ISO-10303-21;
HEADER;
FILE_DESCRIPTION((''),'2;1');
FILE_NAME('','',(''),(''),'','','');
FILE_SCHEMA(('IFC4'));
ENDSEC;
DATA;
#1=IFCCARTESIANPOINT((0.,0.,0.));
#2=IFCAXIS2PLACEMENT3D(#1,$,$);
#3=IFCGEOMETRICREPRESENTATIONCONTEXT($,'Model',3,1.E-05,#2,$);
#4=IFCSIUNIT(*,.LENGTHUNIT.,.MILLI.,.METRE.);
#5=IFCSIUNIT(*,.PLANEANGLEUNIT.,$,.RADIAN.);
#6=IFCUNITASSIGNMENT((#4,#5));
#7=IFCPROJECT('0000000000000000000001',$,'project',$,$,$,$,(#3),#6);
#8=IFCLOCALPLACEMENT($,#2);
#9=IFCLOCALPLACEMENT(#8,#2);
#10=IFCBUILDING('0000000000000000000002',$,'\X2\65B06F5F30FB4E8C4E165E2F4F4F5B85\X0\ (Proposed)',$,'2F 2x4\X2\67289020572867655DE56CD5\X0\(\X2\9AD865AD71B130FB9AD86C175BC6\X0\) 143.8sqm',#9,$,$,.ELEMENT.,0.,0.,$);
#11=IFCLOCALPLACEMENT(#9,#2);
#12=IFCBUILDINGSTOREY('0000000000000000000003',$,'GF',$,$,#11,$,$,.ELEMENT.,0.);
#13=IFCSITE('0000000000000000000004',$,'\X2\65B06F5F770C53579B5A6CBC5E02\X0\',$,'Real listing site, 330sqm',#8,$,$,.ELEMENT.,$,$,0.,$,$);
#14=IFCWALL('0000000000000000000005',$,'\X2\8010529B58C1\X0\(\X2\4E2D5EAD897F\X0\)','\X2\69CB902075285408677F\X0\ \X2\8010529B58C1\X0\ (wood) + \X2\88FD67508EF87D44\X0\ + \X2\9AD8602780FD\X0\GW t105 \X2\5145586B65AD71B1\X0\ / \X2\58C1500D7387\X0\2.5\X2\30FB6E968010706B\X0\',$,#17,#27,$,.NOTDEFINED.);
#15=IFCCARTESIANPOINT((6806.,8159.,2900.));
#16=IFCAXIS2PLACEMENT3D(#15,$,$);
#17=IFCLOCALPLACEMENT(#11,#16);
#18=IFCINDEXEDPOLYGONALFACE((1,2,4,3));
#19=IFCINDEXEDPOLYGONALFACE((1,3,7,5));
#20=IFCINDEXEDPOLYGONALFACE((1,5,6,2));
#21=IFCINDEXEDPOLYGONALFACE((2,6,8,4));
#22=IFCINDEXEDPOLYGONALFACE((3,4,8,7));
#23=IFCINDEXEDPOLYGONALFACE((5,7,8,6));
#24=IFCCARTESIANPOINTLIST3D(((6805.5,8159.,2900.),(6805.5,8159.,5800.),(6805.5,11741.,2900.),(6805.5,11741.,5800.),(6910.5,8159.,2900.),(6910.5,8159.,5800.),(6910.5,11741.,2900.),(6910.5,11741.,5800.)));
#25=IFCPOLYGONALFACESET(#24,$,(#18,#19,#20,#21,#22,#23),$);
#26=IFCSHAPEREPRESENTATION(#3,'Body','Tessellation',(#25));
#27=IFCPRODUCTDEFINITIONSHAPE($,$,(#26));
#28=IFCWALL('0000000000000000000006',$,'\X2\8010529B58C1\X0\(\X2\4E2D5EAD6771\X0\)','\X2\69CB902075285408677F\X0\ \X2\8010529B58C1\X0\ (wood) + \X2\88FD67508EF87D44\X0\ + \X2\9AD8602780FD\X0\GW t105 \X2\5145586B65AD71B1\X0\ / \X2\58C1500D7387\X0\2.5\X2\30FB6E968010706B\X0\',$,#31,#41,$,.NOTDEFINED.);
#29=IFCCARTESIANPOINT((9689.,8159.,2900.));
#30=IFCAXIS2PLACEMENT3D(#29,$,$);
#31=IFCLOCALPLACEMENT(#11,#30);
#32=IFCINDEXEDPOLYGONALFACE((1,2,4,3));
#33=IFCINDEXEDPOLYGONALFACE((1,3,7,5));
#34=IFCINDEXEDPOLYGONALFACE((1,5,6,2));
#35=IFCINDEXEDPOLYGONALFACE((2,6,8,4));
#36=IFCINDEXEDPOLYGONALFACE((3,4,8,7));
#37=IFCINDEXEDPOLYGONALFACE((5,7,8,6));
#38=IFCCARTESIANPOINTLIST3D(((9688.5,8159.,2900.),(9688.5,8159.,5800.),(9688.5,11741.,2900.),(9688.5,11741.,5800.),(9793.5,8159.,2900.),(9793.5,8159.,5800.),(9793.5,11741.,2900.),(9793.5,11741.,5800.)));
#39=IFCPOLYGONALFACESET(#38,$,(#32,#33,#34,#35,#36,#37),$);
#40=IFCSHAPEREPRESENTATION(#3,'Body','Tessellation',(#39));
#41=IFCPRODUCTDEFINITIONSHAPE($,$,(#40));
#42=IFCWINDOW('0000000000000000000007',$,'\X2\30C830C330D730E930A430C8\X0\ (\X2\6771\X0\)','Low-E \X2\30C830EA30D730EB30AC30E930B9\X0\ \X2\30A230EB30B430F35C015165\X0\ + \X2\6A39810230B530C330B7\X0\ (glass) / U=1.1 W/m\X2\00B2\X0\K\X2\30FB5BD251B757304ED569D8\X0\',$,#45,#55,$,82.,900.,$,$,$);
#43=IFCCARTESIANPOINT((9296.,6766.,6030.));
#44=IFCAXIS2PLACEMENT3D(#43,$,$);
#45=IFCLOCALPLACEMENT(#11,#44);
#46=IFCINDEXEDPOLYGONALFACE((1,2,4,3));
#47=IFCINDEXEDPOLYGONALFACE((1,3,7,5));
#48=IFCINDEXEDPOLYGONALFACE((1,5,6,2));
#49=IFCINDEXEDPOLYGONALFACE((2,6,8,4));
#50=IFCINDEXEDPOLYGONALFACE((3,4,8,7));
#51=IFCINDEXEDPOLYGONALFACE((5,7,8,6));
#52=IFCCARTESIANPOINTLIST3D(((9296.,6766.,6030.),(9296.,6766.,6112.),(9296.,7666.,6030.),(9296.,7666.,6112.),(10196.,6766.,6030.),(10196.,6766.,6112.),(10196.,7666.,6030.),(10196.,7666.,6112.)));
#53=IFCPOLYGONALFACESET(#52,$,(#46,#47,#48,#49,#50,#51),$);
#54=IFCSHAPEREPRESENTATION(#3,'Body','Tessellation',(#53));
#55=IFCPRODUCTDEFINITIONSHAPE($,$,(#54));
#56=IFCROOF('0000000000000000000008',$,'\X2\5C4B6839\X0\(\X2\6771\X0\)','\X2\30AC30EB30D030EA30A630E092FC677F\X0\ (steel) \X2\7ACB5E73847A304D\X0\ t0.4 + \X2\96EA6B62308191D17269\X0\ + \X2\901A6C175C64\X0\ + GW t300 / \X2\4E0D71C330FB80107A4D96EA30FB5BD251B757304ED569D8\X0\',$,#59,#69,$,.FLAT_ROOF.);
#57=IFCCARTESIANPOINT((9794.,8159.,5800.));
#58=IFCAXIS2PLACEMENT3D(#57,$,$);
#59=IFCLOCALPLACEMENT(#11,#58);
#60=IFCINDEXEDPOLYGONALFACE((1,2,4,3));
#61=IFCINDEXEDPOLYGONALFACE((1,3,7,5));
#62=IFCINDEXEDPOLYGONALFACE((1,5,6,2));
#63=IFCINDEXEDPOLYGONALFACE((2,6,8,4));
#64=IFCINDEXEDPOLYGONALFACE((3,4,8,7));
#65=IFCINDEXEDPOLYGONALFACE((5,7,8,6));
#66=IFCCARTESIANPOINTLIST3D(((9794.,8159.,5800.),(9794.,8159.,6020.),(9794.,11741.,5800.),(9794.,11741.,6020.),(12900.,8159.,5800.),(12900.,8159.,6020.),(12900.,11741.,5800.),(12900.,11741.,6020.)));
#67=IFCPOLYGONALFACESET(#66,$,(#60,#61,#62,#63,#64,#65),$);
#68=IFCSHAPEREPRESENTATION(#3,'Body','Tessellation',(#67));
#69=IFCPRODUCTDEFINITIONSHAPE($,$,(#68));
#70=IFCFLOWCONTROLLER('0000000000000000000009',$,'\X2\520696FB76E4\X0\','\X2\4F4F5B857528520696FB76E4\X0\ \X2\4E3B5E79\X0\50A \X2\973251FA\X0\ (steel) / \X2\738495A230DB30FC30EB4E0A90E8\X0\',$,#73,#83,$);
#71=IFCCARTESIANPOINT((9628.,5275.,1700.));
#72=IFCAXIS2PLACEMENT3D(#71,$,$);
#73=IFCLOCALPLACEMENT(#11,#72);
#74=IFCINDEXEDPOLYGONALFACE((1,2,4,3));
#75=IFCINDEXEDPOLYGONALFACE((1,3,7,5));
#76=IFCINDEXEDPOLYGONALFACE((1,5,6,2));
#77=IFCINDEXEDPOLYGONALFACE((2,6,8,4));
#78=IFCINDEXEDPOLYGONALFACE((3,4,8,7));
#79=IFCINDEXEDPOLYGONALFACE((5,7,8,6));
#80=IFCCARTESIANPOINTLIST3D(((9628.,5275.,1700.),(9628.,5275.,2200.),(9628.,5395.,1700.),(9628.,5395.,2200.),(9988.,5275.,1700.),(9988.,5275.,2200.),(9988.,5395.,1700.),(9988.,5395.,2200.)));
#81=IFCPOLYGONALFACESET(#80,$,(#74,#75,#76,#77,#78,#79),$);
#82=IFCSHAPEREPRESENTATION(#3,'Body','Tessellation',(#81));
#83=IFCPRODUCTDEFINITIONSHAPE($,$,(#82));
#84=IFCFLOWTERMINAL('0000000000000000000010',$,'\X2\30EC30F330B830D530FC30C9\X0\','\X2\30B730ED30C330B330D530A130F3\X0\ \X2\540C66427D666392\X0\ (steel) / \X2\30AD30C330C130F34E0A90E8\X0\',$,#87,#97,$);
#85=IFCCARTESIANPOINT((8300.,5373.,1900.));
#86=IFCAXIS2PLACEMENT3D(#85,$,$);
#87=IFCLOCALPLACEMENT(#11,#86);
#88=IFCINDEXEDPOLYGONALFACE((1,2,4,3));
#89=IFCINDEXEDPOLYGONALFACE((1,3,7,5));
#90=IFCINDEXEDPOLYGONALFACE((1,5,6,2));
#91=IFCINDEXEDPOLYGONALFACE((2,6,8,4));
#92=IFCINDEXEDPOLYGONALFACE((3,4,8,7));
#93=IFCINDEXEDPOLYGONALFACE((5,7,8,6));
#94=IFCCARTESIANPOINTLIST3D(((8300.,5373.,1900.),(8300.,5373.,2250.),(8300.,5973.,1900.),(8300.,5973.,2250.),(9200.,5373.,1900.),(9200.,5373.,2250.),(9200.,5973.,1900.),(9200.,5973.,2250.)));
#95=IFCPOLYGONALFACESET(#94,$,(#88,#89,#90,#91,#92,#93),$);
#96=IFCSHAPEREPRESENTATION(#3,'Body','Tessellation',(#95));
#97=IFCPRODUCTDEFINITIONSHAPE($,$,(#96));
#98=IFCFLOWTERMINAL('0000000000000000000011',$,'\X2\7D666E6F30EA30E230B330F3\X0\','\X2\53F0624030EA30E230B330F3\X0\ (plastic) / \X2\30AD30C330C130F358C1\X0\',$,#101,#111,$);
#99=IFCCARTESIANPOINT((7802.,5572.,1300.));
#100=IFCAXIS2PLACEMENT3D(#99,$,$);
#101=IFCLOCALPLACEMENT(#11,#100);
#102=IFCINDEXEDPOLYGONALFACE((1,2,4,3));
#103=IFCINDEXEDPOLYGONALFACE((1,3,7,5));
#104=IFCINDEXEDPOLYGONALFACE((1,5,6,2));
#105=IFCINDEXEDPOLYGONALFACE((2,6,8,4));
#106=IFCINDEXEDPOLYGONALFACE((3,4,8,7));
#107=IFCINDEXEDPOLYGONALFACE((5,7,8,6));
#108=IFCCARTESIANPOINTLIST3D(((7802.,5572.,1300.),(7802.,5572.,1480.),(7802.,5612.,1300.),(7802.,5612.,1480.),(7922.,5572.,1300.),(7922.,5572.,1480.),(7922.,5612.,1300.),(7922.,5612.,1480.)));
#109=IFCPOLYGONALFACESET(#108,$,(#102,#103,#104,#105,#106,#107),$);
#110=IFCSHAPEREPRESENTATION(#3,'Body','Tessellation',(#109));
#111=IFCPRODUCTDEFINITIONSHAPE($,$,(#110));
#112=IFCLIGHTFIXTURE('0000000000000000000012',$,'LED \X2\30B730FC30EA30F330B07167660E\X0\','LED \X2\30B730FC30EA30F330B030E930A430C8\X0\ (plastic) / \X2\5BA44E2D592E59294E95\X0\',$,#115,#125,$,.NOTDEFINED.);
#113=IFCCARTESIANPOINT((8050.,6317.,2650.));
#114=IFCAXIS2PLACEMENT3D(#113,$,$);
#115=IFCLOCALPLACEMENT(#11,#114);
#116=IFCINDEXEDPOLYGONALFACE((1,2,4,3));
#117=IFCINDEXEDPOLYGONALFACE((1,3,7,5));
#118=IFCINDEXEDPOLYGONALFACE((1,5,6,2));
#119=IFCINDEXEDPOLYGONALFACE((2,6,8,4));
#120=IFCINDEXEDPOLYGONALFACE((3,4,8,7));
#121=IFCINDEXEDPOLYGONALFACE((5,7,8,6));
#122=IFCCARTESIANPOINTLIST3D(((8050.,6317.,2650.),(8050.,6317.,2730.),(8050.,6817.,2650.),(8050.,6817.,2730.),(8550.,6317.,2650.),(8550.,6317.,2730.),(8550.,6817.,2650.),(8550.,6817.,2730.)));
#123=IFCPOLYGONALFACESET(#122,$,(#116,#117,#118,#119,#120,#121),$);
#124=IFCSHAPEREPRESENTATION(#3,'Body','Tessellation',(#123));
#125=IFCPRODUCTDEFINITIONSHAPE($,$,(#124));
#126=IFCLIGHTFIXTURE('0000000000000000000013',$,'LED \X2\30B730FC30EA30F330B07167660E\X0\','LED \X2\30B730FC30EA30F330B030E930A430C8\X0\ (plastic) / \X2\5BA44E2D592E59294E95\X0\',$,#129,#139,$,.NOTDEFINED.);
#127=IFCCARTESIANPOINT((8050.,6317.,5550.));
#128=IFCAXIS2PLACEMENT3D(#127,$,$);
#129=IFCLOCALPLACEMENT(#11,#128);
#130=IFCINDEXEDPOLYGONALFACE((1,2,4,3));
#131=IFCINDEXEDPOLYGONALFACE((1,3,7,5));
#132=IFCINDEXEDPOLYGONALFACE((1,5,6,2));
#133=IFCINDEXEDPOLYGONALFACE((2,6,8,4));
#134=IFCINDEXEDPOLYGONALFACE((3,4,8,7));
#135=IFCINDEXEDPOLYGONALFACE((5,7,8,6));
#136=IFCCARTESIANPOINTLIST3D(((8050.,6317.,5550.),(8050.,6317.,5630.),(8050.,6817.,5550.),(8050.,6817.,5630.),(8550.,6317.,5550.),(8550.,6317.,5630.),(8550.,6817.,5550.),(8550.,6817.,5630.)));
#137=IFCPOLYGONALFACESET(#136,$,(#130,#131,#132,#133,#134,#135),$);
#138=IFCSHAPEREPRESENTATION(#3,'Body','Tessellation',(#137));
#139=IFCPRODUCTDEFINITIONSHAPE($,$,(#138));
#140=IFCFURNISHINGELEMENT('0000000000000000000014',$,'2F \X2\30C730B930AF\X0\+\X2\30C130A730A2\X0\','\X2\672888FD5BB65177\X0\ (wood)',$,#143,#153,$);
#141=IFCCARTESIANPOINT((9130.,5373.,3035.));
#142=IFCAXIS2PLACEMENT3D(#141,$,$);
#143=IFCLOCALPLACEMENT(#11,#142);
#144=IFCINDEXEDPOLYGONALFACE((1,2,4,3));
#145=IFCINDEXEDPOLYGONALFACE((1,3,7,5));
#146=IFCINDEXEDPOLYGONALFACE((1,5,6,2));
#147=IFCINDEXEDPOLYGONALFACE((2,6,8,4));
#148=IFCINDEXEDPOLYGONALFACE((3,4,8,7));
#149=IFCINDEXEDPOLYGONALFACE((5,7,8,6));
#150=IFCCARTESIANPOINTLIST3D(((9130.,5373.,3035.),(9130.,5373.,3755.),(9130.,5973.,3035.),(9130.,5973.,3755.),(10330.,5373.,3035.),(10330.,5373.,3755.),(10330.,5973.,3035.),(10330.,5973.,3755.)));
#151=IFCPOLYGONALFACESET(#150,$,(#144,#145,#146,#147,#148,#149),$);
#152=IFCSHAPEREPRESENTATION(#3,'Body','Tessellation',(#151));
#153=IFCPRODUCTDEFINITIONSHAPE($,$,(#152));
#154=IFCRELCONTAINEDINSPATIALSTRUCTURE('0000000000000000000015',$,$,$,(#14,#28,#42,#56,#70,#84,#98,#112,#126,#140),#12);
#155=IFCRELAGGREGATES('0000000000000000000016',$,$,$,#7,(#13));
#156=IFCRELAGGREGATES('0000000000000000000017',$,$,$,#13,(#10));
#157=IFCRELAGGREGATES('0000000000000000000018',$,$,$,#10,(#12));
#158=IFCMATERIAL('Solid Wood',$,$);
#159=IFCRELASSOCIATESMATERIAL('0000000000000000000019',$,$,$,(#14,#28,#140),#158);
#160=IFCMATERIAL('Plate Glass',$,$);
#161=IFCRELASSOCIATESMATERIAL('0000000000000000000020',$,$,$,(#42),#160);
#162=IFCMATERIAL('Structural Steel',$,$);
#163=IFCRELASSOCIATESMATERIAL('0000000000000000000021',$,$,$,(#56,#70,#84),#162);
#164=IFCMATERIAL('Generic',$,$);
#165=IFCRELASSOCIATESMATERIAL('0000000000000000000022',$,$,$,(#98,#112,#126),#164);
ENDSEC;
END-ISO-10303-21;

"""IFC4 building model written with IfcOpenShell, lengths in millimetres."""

from ifc_helpers import new_model, si_unit, frame, frame_2d, origin, place, context, project, spatial, rectangle, extrude, material, element, save


model = new_model("IFC4")

# Units and contexts
model_context = context("Model", 3, precision=1e-05, world=origin())
ifc_project = project(units=[si_unit("LENGTHUNIT", "METRE", prefix="MILLI"), si_unit("PLANEANGLEUNIT", "RADIAN")], contexts=[model_context])

# Site, building, storey
site_placement = place(None, origin())
site = spatial("IfcSite", under=ifc_project, at=site_placement, Name="新潟県南魚沼市", ObjectType="Real listing site, 330sqm", CompositionType="ELEMENT", RefElevation=0.0)
building_placement = place(site_placement, origin())
building = spatial("IfcBuilding", under=site, at=building_placement, Name="新潟・二世帯住宅 (Proposed)", ObjectType="2F 2x4木造在来工法(高断熱・高気密) 143.8sqm", CompositionType="ELEMENT", ElevationOfRefHeight=0.0, ElevationOfTerrain=0.0)
storey_placement = place(building_placement, origin())
storey = spatial("IfcBuildingStorey", under=building, at=storey_placement, Name="GF", CompositionType="ELEMENT", Elevation=0.0)

# Shared definitions
ifc_material_1 = material(Name="Solid Wood")

# Shared definitions
ifc_material_2 = material(Name="Plate Glass")

# Walls
wall_1_placement = place(storey_placement, frame((6806.0, 8159.0, 2900.0)))
element("IfcWall", 1, at=wall_1_placement, inside=storey, material=ifc_material_1, Name="耐力壁(中庭西)", Description="構造用合板 耐力壁 (wood) + 製材軸組 + 高性能GW t105 充填断熱 / 壁倍率2.5・準耐火", PredefinedType="NOTDEFINED", context=model_context, shape_type="SweptSolid", body=[
    extrude(rectangle(XDim=105.0, YDim=3582.0, at=frame_2d((52.0, 1791.0))), frame((6806.0, 8159.0, 2900.0)), (0.0, 0.0, 1.0), 2900.0),
])
wall_2_placement = place(storey_placement, frame((9689.0, 8159.0, 2900.0)))
element("IfcWall", 2, at=wall_2_placement, inside=storey, material=ifc_material_1, Name="耐力壁(中庭東)", Description="構造用合板 耐力壁 (wood) + 製材軸組 + 高性能GW t105 充填断熱 / 壁倍率2.5・準耐火", PredefinedType="NOTDEFINED", context=model_context, shape_type="SweptSolid", body=[
    extrude(rectangle(XDim=105.0, YDim=3582.0, at=frame_2d((52.0, 1791.0))), frame((9689.0, 8159.0, 2900.0)), (0.0, 0.0, 1.0), 2900.0),
])

# Window
window_1_placement = place(storey_placement, frame((9296.0, 6766.0, 6030.0)))
element("IfcWindow", 3, at=window_1_placement, inside=storey, material=ifc_material_2, Name="トップライト (東)", Description="Low-E トリプルガラス アルゴン封入 + 樹脂サッシ (glass) / U=1.1 W/m²K・寒冷地仕様", OverallHeight=82.0, OverallWidth=900.0, context=model_context, shape_type="SweptSolid", body=[
    extrude(rectangle(XDim=900.0, YDim=900.0, at=frame_2d((450.0, 450.0))), frame((9296.0, 6766.0, 6030.0)), (0.0, 0.0, 1.0), 82.0),
])

# Roof
ifc_material_3 = material(Name="Structural Steel")
for number, where, name in (
    (4, (9794.0, 8159.0, 5800.0), "屋根(東)"),
):
    element("IfcRoof", number, at=place(storey_placement, frame(where)), inside=storey, material=ifc_material_3, Name=name, Description="ガルバリウム鋼板 (steel) 立平葺き t0.4 + 雪止め金物 + 通気層 + GW t300 / 不燃・耐積雪・寒冷地仕様", PredefinedType="FLAT_ROOF", context=model_context, shape_type="SweptSolid", body=[
        extrude(rectangle(XDim=3106.0, YDim=3582.0, at=frame_2d((1553.0, 1791.0))), frame((9794.0, 8159.0, 5800.0)), (0.0, 0.0, 1.0), 220.0),
    ])

# Flow controller
flow_controller_placement = place(storey_placement, frame((9628.0, 5275.0, 1700.0)))
element("IfcFlowController", 5, at=flow_controller_placement, inside=storey, material=ifc_material_3, Name="分電盤", Description="住宅用分電盤 主幹50A 露出 (steel) / 玄関ホール上部", context=model_context, shape_type="SweptSolid", body=[
    extrude(rectangle(XDim=360.0, YDim=120.0, at=frame_2d((180.0, 60.0))), frame((9628.0, 5275.0, 1700.0)), (0.0, 0.0, 1.0), 500.0),
])

# Flow terminals
flow_terminal_1_placement = place(storey_placement, frame((8300.0, 5373.0, 1900.0)))
element("IfcFlowTerminal", 6, at=flow_terminal_1_placement, inside=storey, material=ifc_material_3, Name="レンジフード", Description="シロッコファン 同時給排 (steel) / キッチン上部", context=model_context, shape_type="SweptSolid", body=[
    extrude(rectangle(XDim=900.0, YDim=600.0, at=frame_2d((450.0, 300.0))), frame((8300.0, 5373.0, 1900.0)), (0.0, 0.0, 1.0), 350.0),
])
ifc_material_4 = material(Name="Generic")
flow_terminal_2_placement = place(storey_placement, frame((7802.0, 5572.0, 1300.0)))
element("IfcFlowTerminal", 7, at=flow_terminal_2_placement, inside=storey, material=ifc_material_4, Name="給湯リモコン", Description="台所リモコン (plastic) / キッチン壁", context=model_context, shape_type="SweptSolid", body=[
    extrude(rectangle(XDim=120.0, YDim=40.0, at=frame_2d((60.0, 20.0))), frame((7802.0, 5572.0, 1300.0)), (0.0, 0.0, 1.0), 180.0),
])

# Light fixtures
light_fixture_1_placement = place(storey_placement, frame((8050.0, 6317.0, 2650.0)))
element("IfcLightFixture", 8, at=light_fixture_1_placement, inside=storey, material=ifc_material_4, Name="LED シーリング照明", Description="LED シーリングライト (plastic) / 室中央天井", PredefinedType="NOTDEFINED", context=model_context, shape_type="SweptSolid", body=[
    extrude(rectangle(XDim=500.0, YDim=500.0, at=frame_2d((250.0, 250.0))), frame((8050.0, 6317.0, 2650.0)), (0.0, 0.0, 1.0), 80.0),
])
light_fixture_2_placement = place(storey_placement, frame((8050.0, 6317.0, 5550.0)))
element("IfcLightFixture", 9, at=light_fixture_2_placement, inside=storey, material=ifc_material_4, Name="LED シーリング照明", Description="LED シーリングライト (plastic) / 室中央天井", PredefinedType="NOTDEFINED", context=model_context, shape_type="SweptSolid", body=[
    extrude(rectangle(XDim=500.0, YDim=500.0, at=frame_2d((250.0, 250.0))), frame((8050.0, 6317.0, 5550.0)), (0.0, 0.0, 1.0), 80.0),
])

# Furnishing element
furnishing_placement = place(storey_placement, frame((9130.0, 5373.0, 3035.0)))
element("IfcFurnishingElement", 10, at=furnishing_placement, inside=storey, material=ifc_material_1, Name="2F デスク+チェア", Description="木製家具 (wood)", context=model_context, shape_type="SweptSolid", body=[
    extrude(rectangle(XDim=1200.0, YDim=600.0, at=frame_2d((600.0, 300.0))), frame((9130.0, 5373.0, 3035.0)), (0.0, 0.0, 1.0), 720.0),
])

save(model, "model.ifc")
